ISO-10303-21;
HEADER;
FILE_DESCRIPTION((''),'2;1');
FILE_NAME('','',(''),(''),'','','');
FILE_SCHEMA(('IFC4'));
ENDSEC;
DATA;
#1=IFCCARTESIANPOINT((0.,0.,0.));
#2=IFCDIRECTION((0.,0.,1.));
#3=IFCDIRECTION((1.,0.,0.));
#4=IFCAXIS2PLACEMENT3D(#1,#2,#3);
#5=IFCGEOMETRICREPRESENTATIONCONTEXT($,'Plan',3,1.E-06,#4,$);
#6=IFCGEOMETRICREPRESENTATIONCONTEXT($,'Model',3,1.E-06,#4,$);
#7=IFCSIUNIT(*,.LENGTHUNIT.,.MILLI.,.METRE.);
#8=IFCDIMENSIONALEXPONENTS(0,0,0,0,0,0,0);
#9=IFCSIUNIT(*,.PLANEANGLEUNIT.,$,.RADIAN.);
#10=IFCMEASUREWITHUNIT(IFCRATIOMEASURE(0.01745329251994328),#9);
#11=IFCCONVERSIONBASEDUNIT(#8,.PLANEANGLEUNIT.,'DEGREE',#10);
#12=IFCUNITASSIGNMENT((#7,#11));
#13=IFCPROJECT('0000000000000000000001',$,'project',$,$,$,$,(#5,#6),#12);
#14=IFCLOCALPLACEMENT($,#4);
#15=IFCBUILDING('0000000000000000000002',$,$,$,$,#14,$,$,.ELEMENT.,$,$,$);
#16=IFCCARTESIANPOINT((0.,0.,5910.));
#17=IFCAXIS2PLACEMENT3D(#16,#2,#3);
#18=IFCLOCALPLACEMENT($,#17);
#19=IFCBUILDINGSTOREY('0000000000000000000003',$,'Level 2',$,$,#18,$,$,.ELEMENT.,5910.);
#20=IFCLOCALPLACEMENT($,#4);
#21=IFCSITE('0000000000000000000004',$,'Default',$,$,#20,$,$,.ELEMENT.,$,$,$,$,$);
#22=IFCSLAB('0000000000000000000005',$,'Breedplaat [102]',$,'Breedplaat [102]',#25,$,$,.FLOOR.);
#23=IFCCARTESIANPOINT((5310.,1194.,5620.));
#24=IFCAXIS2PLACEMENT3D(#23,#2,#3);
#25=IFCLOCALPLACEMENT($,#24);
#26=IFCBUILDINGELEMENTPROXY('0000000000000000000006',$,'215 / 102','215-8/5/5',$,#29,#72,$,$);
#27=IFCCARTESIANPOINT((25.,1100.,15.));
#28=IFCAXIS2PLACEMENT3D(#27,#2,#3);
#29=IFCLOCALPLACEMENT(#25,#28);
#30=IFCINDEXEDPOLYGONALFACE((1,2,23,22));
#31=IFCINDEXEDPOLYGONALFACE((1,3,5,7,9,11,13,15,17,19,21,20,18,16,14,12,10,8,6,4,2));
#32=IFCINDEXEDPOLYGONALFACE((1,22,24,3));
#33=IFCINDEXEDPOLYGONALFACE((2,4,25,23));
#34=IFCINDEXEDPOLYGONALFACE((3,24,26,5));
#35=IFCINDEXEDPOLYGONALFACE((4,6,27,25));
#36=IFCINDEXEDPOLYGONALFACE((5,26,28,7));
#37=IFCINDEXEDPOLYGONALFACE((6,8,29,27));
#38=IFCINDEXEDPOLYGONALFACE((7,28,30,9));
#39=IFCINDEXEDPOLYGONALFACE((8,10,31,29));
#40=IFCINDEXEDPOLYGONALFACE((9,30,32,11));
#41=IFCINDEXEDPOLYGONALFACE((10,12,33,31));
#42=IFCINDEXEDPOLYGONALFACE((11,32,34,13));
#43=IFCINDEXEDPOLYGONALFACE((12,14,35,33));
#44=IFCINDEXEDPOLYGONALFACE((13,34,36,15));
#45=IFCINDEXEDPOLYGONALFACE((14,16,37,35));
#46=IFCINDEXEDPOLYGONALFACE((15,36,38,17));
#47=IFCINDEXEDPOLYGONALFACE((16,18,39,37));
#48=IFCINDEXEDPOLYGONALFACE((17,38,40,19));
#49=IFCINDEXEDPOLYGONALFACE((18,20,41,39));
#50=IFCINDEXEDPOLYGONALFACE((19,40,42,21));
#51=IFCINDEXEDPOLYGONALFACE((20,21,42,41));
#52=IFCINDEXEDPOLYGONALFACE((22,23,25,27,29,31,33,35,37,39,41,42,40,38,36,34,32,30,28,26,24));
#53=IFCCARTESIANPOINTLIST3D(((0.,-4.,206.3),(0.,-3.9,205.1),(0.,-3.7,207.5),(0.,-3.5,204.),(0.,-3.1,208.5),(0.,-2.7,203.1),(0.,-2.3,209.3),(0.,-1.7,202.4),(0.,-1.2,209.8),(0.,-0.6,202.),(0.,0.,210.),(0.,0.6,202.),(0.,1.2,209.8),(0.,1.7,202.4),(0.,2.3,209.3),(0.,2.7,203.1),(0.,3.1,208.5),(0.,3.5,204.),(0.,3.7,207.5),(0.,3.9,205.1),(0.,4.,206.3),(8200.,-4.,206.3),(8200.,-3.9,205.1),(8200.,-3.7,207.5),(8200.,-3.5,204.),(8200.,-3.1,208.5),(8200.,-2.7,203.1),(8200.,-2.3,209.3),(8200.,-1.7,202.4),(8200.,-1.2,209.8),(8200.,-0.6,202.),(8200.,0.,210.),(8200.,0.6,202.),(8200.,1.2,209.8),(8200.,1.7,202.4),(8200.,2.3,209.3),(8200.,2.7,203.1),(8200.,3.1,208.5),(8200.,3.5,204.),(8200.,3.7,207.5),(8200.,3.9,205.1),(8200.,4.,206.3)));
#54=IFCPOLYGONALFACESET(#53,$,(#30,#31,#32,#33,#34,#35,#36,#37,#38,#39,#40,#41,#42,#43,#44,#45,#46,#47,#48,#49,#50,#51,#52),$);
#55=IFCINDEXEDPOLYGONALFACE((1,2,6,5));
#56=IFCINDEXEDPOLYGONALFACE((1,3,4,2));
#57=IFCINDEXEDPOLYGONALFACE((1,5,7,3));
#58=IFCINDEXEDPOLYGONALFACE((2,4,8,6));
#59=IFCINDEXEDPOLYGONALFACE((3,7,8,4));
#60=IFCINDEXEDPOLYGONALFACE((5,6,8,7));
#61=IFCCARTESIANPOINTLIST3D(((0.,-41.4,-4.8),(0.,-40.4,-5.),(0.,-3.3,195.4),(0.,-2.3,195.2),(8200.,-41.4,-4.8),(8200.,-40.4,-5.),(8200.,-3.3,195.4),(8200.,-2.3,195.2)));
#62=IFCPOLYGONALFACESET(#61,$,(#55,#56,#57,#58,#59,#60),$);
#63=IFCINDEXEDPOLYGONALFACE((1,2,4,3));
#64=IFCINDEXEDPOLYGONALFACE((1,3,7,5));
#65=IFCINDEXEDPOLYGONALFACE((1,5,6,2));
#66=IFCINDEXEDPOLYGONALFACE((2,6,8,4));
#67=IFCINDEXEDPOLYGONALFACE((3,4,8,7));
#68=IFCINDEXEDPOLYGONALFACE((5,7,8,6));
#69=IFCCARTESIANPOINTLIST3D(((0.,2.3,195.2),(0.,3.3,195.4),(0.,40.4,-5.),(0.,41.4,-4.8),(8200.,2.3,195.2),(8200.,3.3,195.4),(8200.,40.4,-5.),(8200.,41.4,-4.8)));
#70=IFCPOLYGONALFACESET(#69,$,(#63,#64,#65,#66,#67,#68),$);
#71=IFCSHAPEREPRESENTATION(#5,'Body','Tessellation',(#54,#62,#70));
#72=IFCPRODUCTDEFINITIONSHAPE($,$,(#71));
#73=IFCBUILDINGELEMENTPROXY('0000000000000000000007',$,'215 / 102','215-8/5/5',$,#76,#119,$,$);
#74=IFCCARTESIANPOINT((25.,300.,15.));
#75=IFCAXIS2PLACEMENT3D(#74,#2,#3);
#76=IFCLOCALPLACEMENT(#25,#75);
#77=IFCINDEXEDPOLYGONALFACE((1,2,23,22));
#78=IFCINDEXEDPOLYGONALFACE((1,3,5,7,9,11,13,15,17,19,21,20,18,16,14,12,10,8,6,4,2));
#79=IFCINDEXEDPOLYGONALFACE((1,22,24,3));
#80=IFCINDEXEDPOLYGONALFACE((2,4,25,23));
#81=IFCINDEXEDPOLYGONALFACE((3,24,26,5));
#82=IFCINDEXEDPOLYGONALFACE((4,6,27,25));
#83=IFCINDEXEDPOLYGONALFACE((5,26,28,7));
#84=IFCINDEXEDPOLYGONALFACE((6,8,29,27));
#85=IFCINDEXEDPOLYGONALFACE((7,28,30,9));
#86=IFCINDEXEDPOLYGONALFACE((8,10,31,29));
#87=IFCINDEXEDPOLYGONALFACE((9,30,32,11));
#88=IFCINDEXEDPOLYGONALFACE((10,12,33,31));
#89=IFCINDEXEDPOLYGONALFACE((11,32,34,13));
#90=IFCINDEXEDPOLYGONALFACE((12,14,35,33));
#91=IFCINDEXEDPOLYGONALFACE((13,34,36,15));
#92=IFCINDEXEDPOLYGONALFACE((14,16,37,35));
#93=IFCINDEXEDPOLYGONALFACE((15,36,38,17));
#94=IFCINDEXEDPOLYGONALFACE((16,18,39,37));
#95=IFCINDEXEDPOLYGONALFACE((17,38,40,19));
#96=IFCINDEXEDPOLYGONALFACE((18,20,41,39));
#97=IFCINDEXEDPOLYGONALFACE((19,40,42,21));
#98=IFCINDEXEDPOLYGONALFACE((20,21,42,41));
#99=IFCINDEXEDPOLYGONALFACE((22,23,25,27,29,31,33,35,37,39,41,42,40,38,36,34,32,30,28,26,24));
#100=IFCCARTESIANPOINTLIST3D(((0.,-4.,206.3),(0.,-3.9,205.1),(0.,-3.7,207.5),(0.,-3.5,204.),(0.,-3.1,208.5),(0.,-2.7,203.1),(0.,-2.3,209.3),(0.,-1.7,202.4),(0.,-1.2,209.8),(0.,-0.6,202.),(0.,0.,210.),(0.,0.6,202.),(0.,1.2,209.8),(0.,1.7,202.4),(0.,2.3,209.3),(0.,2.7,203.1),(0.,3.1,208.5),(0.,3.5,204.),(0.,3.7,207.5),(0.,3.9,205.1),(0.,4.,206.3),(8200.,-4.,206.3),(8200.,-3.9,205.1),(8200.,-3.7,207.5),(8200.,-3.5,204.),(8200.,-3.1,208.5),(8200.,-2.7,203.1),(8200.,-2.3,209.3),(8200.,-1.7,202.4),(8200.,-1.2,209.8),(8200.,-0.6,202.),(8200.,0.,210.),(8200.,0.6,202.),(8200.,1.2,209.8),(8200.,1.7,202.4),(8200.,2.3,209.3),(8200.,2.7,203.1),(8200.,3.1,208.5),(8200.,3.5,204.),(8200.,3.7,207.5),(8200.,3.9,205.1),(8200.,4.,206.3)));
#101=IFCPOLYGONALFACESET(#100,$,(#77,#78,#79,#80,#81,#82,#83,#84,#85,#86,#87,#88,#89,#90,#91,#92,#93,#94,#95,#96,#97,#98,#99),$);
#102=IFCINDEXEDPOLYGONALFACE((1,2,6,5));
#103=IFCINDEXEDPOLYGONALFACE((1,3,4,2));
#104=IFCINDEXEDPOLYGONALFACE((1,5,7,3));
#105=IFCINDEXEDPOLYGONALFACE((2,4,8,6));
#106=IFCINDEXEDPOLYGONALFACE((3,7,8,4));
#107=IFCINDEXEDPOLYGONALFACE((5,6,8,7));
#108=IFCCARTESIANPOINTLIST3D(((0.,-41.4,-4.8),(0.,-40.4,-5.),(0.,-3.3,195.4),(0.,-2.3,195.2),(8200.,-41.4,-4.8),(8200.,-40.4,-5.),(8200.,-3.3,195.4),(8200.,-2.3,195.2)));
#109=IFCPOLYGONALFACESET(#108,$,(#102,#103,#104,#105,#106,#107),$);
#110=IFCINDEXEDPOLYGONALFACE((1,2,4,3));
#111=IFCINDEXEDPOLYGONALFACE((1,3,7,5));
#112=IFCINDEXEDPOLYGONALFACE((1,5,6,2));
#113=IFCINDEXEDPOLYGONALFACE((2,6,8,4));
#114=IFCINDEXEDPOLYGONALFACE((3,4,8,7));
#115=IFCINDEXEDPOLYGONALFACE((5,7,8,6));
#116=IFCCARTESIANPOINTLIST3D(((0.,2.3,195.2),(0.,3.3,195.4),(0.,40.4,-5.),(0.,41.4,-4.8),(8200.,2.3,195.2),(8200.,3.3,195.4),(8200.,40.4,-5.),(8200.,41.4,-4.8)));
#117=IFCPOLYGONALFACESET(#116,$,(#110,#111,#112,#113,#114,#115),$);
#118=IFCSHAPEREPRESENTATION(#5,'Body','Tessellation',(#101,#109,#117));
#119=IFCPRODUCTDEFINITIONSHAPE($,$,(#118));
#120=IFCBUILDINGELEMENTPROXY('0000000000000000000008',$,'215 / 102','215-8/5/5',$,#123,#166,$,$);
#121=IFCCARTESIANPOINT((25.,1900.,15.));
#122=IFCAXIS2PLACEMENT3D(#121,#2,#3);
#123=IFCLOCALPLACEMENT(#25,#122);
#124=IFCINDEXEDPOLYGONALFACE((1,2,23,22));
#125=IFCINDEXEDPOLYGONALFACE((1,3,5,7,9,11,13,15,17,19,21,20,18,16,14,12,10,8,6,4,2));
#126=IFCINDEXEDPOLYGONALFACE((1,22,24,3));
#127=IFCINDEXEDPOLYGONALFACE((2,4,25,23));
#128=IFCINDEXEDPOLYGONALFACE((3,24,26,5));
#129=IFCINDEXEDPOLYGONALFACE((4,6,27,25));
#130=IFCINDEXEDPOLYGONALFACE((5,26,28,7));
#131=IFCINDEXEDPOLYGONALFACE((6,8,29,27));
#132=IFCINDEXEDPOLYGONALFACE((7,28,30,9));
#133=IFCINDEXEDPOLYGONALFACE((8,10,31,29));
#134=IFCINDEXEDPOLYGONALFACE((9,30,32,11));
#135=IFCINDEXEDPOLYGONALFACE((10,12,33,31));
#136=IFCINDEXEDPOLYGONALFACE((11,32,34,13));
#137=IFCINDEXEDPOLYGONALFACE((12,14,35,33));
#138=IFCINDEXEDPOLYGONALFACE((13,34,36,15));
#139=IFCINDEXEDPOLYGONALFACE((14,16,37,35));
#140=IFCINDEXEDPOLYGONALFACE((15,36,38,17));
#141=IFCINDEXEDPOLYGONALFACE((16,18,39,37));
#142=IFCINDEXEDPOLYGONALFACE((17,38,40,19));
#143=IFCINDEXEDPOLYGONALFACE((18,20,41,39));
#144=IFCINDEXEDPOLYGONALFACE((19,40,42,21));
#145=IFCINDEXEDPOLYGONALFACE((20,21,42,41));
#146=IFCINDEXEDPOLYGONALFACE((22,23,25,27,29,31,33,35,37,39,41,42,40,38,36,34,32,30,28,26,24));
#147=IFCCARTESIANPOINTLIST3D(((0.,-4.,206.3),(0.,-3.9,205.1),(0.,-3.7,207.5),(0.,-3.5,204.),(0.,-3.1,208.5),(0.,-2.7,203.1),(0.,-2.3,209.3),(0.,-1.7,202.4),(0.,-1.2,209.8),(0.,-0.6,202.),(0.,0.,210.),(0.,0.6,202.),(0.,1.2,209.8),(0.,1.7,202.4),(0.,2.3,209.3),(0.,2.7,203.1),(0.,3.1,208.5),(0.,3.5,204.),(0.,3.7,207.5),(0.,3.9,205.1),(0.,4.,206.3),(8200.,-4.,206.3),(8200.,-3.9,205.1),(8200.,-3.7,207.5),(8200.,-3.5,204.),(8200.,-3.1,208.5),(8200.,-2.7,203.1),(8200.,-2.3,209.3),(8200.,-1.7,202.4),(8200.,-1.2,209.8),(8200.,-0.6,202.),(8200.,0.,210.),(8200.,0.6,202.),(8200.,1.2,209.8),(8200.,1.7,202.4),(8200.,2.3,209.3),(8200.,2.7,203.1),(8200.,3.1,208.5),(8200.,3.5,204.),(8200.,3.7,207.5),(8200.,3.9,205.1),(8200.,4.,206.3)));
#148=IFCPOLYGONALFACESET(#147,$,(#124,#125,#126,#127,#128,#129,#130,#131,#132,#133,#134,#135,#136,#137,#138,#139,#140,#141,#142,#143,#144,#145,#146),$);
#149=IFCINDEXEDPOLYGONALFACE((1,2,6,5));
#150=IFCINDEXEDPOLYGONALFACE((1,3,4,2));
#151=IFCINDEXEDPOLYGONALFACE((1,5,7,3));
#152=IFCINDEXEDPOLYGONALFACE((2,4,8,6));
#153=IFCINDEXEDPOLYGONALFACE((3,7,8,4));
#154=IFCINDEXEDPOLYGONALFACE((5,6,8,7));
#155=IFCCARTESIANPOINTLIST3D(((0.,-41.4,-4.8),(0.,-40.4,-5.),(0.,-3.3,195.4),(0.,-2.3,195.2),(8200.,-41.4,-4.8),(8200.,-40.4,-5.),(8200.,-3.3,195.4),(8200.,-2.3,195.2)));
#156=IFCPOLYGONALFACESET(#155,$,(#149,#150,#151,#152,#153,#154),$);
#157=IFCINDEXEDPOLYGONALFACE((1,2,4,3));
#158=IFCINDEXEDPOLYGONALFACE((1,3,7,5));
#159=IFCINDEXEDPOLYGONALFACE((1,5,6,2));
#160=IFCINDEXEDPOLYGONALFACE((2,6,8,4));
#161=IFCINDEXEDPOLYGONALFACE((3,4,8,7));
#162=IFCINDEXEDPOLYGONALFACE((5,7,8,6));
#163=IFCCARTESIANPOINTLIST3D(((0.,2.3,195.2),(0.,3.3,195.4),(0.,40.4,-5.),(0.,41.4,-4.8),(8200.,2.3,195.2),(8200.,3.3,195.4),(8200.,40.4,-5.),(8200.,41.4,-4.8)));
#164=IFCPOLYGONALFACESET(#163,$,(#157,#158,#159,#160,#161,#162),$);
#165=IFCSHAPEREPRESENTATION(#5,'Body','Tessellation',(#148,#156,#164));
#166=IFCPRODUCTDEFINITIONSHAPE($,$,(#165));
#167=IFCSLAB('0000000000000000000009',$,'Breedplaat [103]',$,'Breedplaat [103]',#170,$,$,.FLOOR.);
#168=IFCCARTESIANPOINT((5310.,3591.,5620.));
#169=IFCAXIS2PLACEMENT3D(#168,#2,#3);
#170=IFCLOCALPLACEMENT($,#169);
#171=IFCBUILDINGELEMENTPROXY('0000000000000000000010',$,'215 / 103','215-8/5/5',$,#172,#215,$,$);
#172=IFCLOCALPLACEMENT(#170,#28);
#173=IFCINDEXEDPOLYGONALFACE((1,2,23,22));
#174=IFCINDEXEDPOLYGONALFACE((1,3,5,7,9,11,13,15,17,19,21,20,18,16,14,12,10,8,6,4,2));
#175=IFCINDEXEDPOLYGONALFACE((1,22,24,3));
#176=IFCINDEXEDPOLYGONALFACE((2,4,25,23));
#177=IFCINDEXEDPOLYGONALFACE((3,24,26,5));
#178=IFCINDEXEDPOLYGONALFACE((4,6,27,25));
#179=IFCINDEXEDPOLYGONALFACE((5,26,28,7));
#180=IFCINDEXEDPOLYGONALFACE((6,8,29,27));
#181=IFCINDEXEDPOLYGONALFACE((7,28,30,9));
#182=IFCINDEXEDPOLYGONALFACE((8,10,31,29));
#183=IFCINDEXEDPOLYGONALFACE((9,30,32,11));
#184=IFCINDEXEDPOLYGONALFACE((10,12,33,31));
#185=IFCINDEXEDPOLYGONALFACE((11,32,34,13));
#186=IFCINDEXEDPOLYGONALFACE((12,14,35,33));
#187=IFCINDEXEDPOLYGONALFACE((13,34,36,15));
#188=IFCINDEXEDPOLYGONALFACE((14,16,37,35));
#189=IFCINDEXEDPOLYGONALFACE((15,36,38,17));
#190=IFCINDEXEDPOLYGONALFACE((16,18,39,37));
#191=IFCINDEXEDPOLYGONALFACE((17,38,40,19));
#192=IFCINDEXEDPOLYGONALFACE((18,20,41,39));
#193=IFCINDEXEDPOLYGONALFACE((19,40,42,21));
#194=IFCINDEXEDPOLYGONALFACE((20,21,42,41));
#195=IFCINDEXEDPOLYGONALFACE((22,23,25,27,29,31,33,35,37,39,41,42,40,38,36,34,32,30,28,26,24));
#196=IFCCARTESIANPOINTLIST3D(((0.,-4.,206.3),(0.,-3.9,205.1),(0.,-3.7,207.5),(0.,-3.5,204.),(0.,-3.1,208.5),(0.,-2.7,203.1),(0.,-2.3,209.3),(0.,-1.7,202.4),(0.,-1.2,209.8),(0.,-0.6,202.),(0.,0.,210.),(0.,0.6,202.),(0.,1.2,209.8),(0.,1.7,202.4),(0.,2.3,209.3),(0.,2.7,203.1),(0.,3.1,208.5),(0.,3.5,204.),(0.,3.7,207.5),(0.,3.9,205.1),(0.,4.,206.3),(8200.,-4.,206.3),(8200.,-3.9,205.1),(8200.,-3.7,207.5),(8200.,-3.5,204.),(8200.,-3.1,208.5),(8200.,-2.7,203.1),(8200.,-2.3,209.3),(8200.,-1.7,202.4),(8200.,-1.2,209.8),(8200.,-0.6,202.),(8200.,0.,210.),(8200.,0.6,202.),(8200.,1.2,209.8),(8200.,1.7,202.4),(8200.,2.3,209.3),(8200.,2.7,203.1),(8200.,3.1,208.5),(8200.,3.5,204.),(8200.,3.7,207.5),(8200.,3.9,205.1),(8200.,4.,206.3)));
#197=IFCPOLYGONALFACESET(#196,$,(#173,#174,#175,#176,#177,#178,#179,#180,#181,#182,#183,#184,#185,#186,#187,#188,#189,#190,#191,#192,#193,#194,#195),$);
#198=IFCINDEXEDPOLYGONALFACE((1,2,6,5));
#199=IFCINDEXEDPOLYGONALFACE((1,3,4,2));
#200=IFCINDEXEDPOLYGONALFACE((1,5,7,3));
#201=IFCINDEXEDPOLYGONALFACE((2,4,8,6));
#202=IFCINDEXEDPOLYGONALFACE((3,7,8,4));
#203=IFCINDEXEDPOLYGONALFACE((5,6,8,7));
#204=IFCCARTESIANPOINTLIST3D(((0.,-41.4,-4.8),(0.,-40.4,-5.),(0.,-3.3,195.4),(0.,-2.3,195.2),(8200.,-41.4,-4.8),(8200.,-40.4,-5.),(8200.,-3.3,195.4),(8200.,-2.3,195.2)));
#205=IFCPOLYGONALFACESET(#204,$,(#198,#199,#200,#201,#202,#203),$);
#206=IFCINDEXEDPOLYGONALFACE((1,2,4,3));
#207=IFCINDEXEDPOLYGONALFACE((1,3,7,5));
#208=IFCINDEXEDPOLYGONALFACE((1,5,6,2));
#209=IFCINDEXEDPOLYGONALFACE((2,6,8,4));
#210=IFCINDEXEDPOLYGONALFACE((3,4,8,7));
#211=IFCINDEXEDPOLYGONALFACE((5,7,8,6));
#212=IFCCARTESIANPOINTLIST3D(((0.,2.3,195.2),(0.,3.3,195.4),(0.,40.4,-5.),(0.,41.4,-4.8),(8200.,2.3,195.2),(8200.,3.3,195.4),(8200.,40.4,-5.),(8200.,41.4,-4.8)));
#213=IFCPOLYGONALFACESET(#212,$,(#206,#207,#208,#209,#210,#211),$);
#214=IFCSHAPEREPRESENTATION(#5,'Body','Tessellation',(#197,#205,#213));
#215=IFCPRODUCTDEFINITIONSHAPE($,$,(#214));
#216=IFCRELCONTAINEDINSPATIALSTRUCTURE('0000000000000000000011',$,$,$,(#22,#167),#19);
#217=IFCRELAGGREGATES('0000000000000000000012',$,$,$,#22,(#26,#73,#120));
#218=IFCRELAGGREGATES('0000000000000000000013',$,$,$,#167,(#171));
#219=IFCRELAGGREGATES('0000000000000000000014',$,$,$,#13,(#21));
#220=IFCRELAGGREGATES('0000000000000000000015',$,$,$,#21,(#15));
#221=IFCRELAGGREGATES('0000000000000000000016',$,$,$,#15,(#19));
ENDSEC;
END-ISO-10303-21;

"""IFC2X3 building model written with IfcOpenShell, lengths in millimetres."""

from ifc_helpers import new_model, entity, si_unit, converted_unit, frame, origin_with_axes, origin_2d_with_axis, place, context, project, spatial, rectangle, circle, extrude, element, aggregate, save


model = new_model("IFC2X3")

# Units and contexts
plan_context = context("Plan", 3, precision=1e-06, world=origin_with_axes())
model_context = context("Model", 3, precision=1e-06, world=origin_with_axes())
ifc_project = project(units=[si_unit("LENGTHUNIT", "METRE", prefix="MILLI"), converted_unit("PLANEANGLEUNIT", "DEGREE", entity("IfcRatioMeasure", 0.01745329251994328), si_unit("PLANEANGLEUNIT", "RADIAN"), dimensions=[0, 0, 0, 0, 0, 0, 0])], contexts=[plan_context, model_context])

# Site, building, storey
site_placement = place(None, origin_with_axes())
site = spatial("IfcSite", under=ifc_project, at=site_placement, Name="Default", CompositionType="ELEMENT")
building_placement = place(None, origin_with_axes())
building = spatial("IfcBuilding", under=site, at=building_placement, CompositionType="ELEMENT")
storey_placement = place(None, frame((0.0, 0.0, 5910.0), z_axis=(0.0, 0.0, 1.0), x_axis=(1.0, 0.0, 0.0)))
storey = spatial("IfcBuildingStorey", under=building, at=storey_placement, Name="Level 2", CompositionType="ELEMENT", Elevation=5910.0)

# Slabs, building element proxies
slab_1_placement = place(None, frame((5310.0, 1194.0, 5620.0), z_axis=(0.0, 0.0, 1.0), x_axis=(1.0, 0.0, 0.0)))
slab_1 = element("IfcSlab", 1, at=slab_1_placement, inside=storey, Name="Breedplaat [102]", ObjectType="Breedplaat [102]", PredefinedType="FLOOR")
proxy_1_placement = place(slab_1_placement, frame((25.0, 1100.0, 15.0), z_axis=(0.0, 0.0, 1.0), x_axis=(1.0, 0.0, 0.0)))
proxy_1 = element("IfcBuildingElementProxy", 2, at=proxy_1_placement, Name="215 / 102", Description="215-8/5/5", context=plan_context, shape_type="SweptSolid", body=[
    extrude(circle(Radius=4.0, at=origin_2d_with_axis()), frame((0.0, 0.0, 206.0), z_axis=(1.0, 0.0, 0.0), x_axis=(0.0, 0.0, 1.0)), (0.0, 0.0, 1.0), 8200.0),
    extrude(rectangle(XDim=203.8, YDim=1.0, at=origin_2d_with_axis()), frame((0.0, -21.9, 95.2), z_axis=(1.0, 0.0, 0.0), x_axis=(0.0, 0.187112, 0.982339)), (0.0, 0.0, 1.0), 8200.0),
    extrude(rectangle(XDim=203.8, YDim=1.0, at=origin_2d_with_axis()), frame((0.0, 21.9, 95.2), z_axis=(1.0, 0.0, 0.0), x_axis=(0.0, -0.187112, 0.982339)), (0.0, 0.0, 1.0), 8200.0),
])
proxy_2_placement = place(slab_1_placement, frame((25.0, 300.0, 15.0), z_axis=(0.0, 0.0, 1.0), x_axis=(1.0, 0.0, 0.0)))
proxy_2 = element("IfcBuildingElementProxy", 3, at=proxy_2_placement, Name="215 / 102", Description="215-8/5/5", context=plan_context, shape_type="SweptSolid", body=[
    extrude(circle(Radius=4.0, at=origin_2d_with_axis()), frame((0.0, 0.0, 206.0), z_axis=(1.0, 0.0, 0.0), x_axis=(0.0, 0.0, 1.0)), (0.0, 0.0, 1.0), 8200.0),
    extrude(rectangle(XDim=203.8, YDim=1.0, at=origin_2d_with_axis()), frame((0.0, -21.9, 95.2), z_axis=(1.0, 0.0, 0.0), x_axis=(0.0, 0.187112, 0.982339)), (0.0, 0.0, 1.0), 8200.0),
    extrude(rectangle(XDim=203.8, YDim=1.0, at=origin_2d_with_axis()), frame((0.0, 21.9, 95.2), z_axis=(1.0, 0.0, 0.0), x_axis=(0.0, -0.187112, 0.982339)), (0.0, 0.0, 1.0), 8200.0),
])
proxy_3_placement = place(slab_1_placement, frame((25.0, 1900.0, 15.0), z_axis=(0.0, 0.0, 1.0), x_axis=(1.0, 0.0, 0.0)))
proxy_3 = element("IfcBuildingElementProxy", 4, at=proxy_3_placement, Name="215 / 102", Description="215-8/5/5", context=plan_context, shape_type="SweptSolid", body=[
    extrude(circle(Radius=4.0, at=origin_2d_with_axis()), frame((0.0, 0.0, 206.0), z_axis=(1.0, 0.0, 0.0), x_axis=(0.0, 0.0, 1.0)), (0.0, 0.0, 1.0), 8200.0),
    extrude(rectangle(XDim=203.8, YDim=1.0, at=origin_2d_with_axis()), frame((0.0, -21.9, 95.2), z_axis=(1.0, 0.0, 0.0), x_axis=(0.0, 0.187112, 0.982339)), (0.0, 0.0, 1.0), 8200.0),
    extrude(rectangle(XDim=203.8, YDim=1.0, at=origin_2d_with_axis()), frame((0.0, 21.9, 95.2), z_axis=(1.0, 0.0, 0.0), x_axis=(0.0, -0.187112, 0.982339)), (0.0, 0.0, 1.0), 8200.0),
])
aggregate(slab_1, [proxy_1, proxy_2, proxy_3])
slab_2_placement = place(None, frame((5310.0, 3591.0, 5620.0), z_axis=(0.0, 0.0, 1.0), x_axis=(1.0, 0.0, 0.0)))
slab_2 = element("IfcSlab", 5, at=slab_2_placement, inside=storey, Name="Breedplaat [103]", ObjectType="Breedplaat [103]", PredefinedType="FLOOR")
proxy_4_placement = place(slab_2_placement, frame((25.0, 1100.0, 15.0), z_axis=(0.0, 0.0, 1.0), x_axis=(1.0, 0.0, 0.0)))
proxy_4 = element("IfcBuildingElementProxy", 6, at=proxy_4_placement, Name="215 / 103", Description="215-8/5/5", context=plan_context, shape_type="SweptSolid", body=[
    extrude(circle(Radius=4.0, at=origin_2d_with_axis()), frame((0.0, 0.0, 206.0), z_axis=(1.0, 0.0, 0.0), x_axis=(0.0, 0.0, 1.0)), (0.0, 0.0, 1.0), 8200.0),
    extrude(rectangle(XDim=203.8, YDim=1.0, at=origin_2d_with_axis()), frame((0.0, -21.9, 95.2), z_axis=(1.0, 0.0, 0.0), x_axis=(0.0, 0.187112, 0.982339)), (0.0, 0.0, 1.0), 8200.0),
    extrude(rectangle(XDim=203.8, YDim=1.0, at=origin_2d_with_axis()), frame((0.0, 21.9, 95.2), z_axis=(1.0, 0.0, 0.0), x_axis=(0.0, -0.187112, 0.982339)), (0.0, 0.0, 1.0), 8200.0),
])
aggregate(slab_2, [proxy_4])

save(model, "model.ifc")
